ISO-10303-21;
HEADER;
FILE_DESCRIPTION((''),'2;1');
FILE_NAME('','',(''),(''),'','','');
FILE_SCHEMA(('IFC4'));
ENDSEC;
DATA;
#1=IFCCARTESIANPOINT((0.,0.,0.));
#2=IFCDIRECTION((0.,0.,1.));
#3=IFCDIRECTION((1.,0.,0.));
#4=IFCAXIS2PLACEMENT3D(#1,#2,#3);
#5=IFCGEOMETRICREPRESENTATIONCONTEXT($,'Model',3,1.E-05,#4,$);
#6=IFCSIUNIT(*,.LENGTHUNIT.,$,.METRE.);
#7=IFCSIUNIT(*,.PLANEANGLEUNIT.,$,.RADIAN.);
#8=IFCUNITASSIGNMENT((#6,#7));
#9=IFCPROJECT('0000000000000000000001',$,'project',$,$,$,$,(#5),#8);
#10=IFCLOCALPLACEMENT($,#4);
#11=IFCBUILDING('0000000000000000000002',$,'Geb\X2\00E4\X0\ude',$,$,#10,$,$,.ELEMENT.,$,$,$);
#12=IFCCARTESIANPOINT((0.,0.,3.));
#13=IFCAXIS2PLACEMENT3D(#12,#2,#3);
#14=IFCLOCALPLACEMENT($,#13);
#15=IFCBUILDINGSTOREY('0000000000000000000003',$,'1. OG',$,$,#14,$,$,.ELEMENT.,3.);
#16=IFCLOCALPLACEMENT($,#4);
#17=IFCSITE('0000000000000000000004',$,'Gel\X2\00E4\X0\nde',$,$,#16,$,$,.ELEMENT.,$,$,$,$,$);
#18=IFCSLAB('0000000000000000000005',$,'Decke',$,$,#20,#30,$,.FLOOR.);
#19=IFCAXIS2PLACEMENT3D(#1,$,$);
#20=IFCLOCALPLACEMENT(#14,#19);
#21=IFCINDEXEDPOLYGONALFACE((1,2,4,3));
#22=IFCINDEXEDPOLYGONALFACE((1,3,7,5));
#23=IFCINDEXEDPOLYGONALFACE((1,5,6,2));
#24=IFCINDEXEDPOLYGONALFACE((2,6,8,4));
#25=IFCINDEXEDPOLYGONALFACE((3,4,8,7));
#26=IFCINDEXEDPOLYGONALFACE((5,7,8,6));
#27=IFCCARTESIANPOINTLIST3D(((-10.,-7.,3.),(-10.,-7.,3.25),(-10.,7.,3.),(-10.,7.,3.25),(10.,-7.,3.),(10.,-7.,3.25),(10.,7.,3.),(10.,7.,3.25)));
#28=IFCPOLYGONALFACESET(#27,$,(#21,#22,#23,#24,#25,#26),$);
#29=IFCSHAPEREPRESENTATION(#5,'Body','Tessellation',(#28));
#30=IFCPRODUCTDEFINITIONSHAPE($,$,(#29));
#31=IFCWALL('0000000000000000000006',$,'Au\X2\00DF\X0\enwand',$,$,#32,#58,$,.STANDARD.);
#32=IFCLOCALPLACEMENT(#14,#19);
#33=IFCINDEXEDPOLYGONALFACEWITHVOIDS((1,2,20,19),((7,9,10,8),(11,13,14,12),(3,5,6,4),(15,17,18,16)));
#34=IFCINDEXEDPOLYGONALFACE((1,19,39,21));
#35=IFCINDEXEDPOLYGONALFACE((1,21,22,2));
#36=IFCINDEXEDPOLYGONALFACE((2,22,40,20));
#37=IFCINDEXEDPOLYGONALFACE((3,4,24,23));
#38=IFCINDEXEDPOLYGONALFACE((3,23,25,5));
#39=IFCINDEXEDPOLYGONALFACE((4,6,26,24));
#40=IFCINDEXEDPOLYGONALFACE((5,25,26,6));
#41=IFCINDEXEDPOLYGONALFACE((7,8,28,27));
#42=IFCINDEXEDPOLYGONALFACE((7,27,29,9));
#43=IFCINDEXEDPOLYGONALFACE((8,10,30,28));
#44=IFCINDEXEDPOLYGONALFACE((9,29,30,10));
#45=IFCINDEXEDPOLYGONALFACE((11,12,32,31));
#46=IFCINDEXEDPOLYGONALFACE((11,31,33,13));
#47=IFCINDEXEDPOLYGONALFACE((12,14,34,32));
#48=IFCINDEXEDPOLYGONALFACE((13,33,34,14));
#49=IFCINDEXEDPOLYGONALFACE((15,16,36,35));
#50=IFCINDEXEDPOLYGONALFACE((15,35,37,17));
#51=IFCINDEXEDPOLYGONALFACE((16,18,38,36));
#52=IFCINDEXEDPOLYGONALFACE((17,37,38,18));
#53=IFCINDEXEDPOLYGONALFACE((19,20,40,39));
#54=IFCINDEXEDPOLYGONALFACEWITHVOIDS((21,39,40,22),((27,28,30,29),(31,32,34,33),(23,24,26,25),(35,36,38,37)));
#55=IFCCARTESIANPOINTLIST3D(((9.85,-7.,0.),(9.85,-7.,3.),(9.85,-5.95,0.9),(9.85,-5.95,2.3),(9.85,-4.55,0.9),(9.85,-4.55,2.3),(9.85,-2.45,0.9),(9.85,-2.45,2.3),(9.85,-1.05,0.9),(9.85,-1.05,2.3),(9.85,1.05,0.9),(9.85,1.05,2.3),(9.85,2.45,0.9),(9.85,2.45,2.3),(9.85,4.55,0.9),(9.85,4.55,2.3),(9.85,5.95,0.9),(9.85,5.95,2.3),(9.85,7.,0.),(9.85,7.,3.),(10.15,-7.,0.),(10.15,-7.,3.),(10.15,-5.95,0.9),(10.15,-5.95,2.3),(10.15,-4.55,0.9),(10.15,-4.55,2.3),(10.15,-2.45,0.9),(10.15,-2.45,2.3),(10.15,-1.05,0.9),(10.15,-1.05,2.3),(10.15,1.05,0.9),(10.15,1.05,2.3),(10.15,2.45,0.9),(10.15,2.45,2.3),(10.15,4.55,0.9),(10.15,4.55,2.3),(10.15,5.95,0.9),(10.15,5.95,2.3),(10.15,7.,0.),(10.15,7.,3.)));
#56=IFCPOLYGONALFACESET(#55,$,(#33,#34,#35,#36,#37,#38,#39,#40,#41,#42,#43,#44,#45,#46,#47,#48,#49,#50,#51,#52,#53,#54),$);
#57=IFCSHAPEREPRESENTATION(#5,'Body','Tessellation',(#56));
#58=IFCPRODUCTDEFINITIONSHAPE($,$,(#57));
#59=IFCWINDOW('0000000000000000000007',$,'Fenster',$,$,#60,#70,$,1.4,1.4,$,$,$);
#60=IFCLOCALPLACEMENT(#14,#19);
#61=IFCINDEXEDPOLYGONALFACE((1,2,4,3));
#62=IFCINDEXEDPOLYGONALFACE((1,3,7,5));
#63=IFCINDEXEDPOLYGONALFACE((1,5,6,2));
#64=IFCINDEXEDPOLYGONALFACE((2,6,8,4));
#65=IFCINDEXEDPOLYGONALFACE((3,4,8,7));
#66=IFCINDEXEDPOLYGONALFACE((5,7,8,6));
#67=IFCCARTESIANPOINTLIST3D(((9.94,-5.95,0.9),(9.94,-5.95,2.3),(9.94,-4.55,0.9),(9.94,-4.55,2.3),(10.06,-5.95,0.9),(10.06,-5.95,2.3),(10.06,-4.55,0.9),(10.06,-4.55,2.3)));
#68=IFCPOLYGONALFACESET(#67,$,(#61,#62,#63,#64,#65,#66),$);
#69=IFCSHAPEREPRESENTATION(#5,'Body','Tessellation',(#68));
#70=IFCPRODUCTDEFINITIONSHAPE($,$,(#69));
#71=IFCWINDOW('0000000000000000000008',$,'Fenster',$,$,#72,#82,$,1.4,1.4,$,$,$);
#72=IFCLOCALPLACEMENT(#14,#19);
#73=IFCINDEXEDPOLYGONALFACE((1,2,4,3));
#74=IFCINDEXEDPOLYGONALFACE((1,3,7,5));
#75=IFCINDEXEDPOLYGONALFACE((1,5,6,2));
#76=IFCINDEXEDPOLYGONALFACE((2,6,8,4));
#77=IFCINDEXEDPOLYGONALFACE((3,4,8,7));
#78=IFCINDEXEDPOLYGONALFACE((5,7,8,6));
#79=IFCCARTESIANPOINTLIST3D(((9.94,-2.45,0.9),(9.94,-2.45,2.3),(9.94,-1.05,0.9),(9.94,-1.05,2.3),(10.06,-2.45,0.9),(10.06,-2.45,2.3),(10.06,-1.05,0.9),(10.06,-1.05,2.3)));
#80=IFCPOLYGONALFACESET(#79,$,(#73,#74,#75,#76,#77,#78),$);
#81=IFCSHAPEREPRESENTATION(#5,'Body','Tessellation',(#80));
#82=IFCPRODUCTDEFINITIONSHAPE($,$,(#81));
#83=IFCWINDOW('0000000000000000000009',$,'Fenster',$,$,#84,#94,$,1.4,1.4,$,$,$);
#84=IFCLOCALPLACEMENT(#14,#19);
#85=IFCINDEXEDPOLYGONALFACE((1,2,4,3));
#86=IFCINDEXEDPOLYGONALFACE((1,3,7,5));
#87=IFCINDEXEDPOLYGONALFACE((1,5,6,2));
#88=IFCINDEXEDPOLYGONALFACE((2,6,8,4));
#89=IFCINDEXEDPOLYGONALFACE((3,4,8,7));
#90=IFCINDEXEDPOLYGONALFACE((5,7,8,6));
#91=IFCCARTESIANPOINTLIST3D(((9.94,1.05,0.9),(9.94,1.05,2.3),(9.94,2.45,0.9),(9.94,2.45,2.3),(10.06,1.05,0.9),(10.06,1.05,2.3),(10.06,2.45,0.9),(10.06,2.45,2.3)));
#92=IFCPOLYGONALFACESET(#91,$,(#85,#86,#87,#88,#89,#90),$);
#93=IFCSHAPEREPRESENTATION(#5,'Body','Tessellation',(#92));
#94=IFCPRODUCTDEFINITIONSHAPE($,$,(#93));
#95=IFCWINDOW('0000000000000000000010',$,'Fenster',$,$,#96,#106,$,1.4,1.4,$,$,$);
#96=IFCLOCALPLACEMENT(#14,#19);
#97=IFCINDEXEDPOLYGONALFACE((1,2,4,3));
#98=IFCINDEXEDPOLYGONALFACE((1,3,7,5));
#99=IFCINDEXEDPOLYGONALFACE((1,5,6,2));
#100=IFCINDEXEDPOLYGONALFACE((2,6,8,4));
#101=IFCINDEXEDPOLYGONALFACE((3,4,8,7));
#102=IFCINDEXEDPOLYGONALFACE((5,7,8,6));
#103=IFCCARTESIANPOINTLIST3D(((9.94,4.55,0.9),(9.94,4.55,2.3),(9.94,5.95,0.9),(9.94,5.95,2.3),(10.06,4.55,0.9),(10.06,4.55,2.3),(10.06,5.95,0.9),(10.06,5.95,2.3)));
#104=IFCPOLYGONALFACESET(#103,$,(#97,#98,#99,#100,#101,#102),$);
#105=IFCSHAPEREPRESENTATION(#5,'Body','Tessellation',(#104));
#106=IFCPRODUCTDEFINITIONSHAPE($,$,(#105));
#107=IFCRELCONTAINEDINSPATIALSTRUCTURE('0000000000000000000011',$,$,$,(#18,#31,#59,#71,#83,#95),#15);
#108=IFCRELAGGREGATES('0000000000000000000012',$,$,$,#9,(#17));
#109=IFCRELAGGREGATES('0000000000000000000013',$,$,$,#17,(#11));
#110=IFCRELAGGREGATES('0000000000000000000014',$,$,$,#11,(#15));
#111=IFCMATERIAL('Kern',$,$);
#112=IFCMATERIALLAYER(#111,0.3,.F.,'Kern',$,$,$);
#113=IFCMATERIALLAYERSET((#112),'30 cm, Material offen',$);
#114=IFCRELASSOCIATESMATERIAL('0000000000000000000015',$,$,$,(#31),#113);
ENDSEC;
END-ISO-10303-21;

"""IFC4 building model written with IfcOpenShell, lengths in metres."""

from ifc_helpers import new_model, si_unit, frame, origin_with_axes, origin_2d, place, context, project, spatial, polyline, rectangle, outline, extrude, material, layer, layer_set, element, fill, save


model = new_model("IFC4")

# Units and contexts
model_context = context("Model", 3, precision=1e-05, world=origin_with_axes())
ifc_project = project(units=[si_unit("LENGTHUNIT", "METRE"), si_unit("PLANEANGLEUNIT", "RADIAN")], contexts=[model_context])

# Site, building, storey
site_placement = place(None, origin_with_axes())
site = spatial("IfcSite", under=ifc_project, at=site_placement, Name="Gelände", CompositionType="ELEMENT")
building_placement = place(None, origin_with_axes())
building = spatial("IfcBuilding", under=site, at=building_placement, Name="Gebäude", CompositionType="ELEMENT")
storey_placement = place(None, frame((0.0, 0.0, 3.0), z_axis=(0.0, 0.0, 1.0), x_axis=(1.0, 0.0, 0.0)))
storey = spatial("IfcBuildingStorey", under=building, at=storey_placement, Name="1. OG", CompositionType="ELEMENT", Elevation=3.0)

# Slab
slab_placement = place(None, frame((0.0, 0.0, 6.0), z_axis=(0.0, 0.0, 1.0), x_axis=(1.0, 0.0, 0.0)))
element("IfcSlab", 1, at=slab_placement, inside=storey, Name="Decke", PredefinedType="FLOOR", context=model_context, shape_type="SweptSolid", body=[
    extrude(outline(polyline([(-10.0, -7.0), (10.0, -7.0), (10.0, 7.0), (-10.0, 7.0), (-10.0, -7.0)])), origin_with_axes(), (0.0, 0.0, 1.0), 0.25),
])

# Wall, openings, windows
ifc_material = material(Name="Kern")
ifc_layer = layer(ifc_material, 0.3, ventilated=False, Name="Kern")
ifc_layer_set = layer_set([ifc_layer], Name="30 cm, Material offen")
wall_1_placement = place(None, frame((10.0, 0.0, 3.0), z_axis=(0.0, 0.0, 1.0), x_axis=(0.0, 1.0, 0.0)))
wall_1 = element("IfcWall", 2, at=wall_1_placement, inside=storey, material=ifc_layer_set, Name="Außenwand", PredefinedType="STANDARD", context=model_context, shape_type="SweptSolid", body=[
    extrude(rectangle(XDim=14.0, YDim=0.3, at=origin_2d()), origin_with_axes(), (0.0, 0.0, 1.0), 3.0),
])
opening_1_placement = place(wall_1_placement, frame((-5.25, 0.0, 0.9), z_axis=(0.0, 0.0, 1.0), x_axis=(1.0, 0.0, 0.0)))
opening_1 = element("IfcOpeningElement", 3, at=opening_1_placement, cuts=wall_1, PredefinedType="OPENING", context=model_context, shape_type="SweptSolid", body=[
    extrude(rectangle(XDim=1.4, YDim=0.34, at=origin_2d()), origin_with_axes(), (0.0, 0.0, 1.0), 1.4),
])
opening_2_placement = place(wall_1_placement, frame((-1.75, 0.0, 0.9), z_axis=(0.0, 0.0, 1.0), x_axis=(1.0, 0.0, 0.0)))
opening_2 = element("IfcOpeningElement", 4, at=opening_2_placement, cuts=wall_1, PredefinedType="OPENING", context=model_context, shape_type="SweptSolid", body=[
    extrude(rectangle(XDim=1.4, YDim=0.34, at=origin_2d()), origin_with_axes(), (0.0, 0.0, 1.0), 1.4),
])
opening_3_placement = place(wall_1_placement, frame((1.75, 0.0, 0.9), z_axis=(0.0, 0.0, 1.0), x_axis=(1.0, 0.0, 0.0)))
opening_3 = element("IfcOpeningElement", 5, at=opening_3_placement, cuts=wall_1, PredefinedType="OPENING", context=model_context, shape_type="SweptSolid", body=[
    extrude(rectangle(XDim=1.4, YDim=0.34, at=origin_2d()), origin_with_axes(), (0.0, 0.0, 1.0), 1.4),
])
opening_4_placement = place(wall_1_placement, frame((5.25, 0.0, 0.9), z_axis=(0.0, 0.0, 1.0), x_axis=(1.0, 0.0, 0.0)))
opening_4 = element("IfcOpeningElement", 6, at=opening_4_placement, cuts=wall_1, PredefinedType="OPENING", context=model_context, shape_type="SweptSolid", body=[
    extrude(rectangle(XDim=1.4, YDim=0.34, at=origin_2d()), origin_with_axes(), (0.0, 0.0, 1.0), 1.4),
])
window_1_placement = place(opening_1_placement, origin_with_axes())
window_1 = element("IfcWindow", 7, at=window_1_placement, inside=storey, Name="Fenster", OverallHeight=1.4, OverallWidth=1.4, context=model_context, shape_type="SweptSolid", body=[
    extrude(rectangle(XDim=1.4, YDim=0.12, at=origin_2d()), origin_with_axes(), (0.0, 0.0, 1.0), 1.4),
])
fill(opening_1, window_1)
window_2_placement = place(opening_2_placement, origin_with_axes())
window_2 = element("IfcWindow", 8, at=window_2_placement, inside=storey, Name="Fenster", OverallHeight=1.4, OverallWidth=1.4, context=model_context, shape_type="SweptSolid", body=[
    extrude(rectangle(XDim=1.4, YDim=0.12, at=origin_2d()), origin_with_axes(), (0.0, 0.0, 1.0), 1.4),
])
fill(opening_2, window_2)
window_3_placement = place(opening_3_placement, origin_with_axes())
window_3 = element("IfcWindow", 9, at=window_3_placement, inside=storey, Name="Fenster", OverallHeight=1.4, OverallWidth=1.4, context=model_context, shape_type="SweptSolid", body=[
    extrude(rectangle(XDim=1.4, YDim=0.12, at=origin_2d()), origin_with_axes(), (0.0, 0.0, 1.0), 1.4),
])
fill(opening_3, window_3)
window_4_placement = place(opening_4_placement, origin_with_axes())
window_4 = element("IfcWindow", 10, at=window_4_placement, inside=storey, Name="Fenster", OverallHeight=1.4, OverallWidth=1.4, context=model_context, shape_type="SweptSolid", body=[
    extrude(rectangle(XDim=1.4, YDim=0.12, at=origin_2d()), origin_with_axes(), (0.0, 0.0, 1.0), 1.4),
])
fill(opening_4, window_4)

save(model, "model.ifc")
